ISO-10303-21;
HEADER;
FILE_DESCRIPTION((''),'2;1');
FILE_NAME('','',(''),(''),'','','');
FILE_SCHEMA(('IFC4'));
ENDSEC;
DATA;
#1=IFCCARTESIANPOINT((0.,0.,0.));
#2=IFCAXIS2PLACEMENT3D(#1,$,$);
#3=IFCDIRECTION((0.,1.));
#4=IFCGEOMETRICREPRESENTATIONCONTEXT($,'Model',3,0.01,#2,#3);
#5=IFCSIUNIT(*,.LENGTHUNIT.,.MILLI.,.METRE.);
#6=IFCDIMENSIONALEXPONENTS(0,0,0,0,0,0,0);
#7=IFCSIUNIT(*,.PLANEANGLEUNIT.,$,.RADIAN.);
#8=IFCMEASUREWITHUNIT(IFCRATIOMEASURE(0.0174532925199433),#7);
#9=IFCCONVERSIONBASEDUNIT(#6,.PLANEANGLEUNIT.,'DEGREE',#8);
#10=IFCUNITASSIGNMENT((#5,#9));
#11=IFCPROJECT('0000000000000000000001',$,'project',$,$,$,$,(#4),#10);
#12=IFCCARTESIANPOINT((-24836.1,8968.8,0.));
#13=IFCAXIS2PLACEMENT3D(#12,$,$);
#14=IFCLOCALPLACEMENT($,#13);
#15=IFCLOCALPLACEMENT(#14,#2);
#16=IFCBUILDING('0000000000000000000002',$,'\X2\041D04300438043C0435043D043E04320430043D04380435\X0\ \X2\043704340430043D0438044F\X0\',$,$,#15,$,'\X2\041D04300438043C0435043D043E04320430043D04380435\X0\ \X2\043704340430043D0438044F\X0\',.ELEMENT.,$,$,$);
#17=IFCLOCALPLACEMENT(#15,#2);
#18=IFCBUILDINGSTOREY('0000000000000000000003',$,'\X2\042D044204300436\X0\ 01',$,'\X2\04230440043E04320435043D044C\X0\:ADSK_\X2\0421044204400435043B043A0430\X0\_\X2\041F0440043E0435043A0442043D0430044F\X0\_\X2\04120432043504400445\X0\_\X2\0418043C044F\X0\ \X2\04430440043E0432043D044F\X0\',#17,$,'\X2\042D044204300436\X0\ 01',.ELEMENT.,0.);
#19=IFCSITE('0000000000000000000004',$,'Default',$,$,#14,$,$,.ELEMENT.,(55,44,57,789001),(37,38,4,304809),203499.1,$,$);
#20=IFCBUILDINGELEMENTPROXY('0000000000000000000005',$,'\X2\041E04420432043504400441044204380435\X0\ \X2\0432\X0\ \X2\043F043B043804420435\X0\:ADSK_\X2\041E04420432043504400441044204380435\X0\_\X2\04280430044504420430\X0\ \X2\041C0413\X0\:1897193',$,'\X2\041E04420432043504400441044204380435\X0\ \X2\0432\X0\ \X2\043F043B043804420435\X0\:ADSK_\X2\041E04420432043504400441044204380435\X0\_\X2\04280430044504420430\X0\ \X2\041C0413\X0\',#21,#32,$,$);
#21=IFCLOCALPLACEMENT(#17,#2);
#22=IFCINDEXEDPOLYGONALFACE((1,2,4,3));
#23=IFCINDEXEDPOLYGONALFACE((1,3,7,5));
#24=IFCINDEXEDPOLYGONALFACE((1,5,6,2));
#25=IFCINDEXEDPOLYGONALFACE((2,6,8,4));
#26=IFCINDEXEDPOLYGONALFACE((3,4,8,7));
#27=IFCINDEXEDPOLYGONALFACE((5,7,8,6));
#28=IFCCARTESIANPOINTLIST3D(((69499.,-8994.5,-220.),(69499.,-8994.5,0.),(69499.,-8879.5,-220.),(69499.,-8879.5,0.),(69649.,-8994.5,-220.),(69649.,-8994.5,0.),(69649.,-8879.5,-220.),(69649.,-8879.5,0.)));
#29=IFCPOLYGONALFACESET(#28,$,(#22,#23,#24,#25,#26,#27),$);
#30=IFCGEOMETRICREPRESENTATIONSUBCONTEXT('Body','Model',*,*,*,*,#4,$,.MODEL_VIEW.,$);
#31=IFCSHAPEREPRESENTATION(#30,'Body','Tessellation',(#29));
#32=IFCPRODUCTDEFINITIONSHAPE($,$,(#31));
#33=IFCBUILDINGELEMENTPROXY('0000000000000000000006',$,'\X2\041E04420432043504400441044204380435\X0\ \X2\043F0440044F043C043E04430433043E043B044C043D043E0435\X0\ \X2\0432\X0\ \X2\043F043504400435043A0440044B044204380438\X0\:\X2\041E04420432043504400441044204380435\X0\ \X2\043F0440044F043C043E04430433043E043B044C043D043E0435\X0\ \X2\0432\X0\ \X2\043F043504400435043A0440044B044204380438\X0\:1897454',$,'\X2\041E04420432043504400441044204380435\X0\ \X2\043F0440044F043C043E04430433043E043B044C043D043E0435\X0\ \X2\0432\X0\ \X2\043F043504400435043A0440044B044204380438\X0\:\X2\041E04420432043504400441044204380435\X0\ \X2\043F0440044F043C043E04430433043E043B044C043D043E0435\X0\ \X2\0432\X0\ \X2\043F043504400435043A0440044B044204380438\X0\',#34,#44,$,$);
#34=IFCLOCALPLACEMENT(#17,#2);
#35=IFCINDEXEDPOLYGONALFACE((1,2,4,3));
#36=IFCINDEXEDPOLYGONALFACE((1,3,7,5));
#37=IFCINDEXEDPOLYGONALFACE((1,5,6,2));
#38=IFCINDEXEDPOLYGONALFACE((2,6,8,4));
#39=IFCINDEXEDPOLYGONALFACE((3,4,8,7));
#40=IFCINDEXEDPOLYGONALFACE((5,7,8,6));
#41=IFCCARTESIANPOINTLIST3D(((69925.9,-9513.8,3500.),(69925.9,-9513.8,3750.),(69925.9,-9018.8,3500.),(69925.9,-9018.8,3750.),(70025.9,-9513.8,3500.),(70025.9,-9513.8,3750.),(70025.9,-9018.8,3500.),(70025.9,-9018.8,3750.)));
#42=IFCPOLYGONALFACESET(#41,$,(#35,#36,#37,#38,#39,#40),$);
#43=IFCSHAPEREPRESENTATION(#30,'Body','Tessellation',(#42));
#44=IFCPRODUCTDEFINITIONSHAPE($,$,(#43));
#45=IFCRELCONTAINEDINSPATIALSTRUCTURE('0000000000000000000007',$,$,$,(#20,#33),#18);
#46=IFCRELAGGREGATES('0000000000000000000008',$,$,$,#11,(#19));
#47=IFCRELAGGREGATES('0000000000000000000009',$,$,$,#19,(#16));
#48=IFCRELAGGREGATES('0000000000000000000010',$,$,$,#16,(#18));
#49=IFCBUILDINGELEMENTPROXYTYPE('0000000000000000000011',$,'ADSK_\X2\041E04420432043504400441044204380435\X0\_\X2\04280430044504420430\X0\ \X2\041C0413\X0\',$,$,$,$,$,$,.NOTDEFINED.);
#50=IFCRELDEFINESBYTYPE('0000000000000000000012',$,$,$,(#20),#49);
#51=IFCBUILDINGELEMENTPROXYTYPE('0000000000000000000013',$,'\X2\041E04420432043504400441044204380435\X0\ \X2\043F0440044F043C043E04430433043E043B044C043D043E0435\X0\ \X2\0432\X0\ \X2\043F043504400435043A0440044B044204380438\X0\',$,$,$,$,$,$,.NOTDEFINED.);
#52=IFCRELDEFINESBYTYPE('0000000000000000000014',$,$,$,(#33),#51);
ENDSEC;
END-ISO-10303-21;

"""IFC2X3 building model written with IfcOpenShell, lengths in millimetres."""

from ifc_helpers import new_model, entity, si_unit, converted_unit, direction, frame, origin, origin_2d_with_axis, place, context, subcontext, project, spatial, rectangle, extrude, type_object, element, save


model = new_model("IFC2X3")

# Units and contexts
model_context = context("Model", 3, precision=0.01, world=origin(), true_north=direction((0.0, 1.0)))
body_context = subcontext(model_context, "Body", "Model", "MODEL_VIEW")
ifc_project = project(units=[si_unit("LENGTHUNIT", "METRE", prefix="MILLI"), converted_unit("PLANEANGLEUNIT", "DEGREE", entity("IfcRatioMeasure", 0.0174532925199433), si_unit("PLANEANGLEUNIT", "RADIAN"), dimensions=[0, 0, 0, 0, 0, 0, 0])], contexts=[model_context])

# Site, building, storey
site_placement = place(None, frame((-24836.1, 8968.8, 0.0)))
site = spatial("IfcSite", under=ifc_project, at=site_placement, Name="Default", CompositionType="ELEMENT", RefLatitude=(55, 44, 57, 789001), RefLongitude=(37, 38, 4, 304809), RefElevation=203499.1)
building_placement = place(site_placement, origin())
building = spatial("IfcBuilding", under=site, at=building_placement, Name="Наименование здания", LongName="Наименование здания", CompositionType="ELEMENT")
storey_placement = place(building_placement, origin())
storey = spatial("IfcBuildingStorey", under=building, at=storey_placement, Name="Этаж 01", ObjectType="Уровень:ADSK_Стрелка_Проектная_Вверх_Имя уровня", LongName="Этаж 01", CompositionType="ELEMENT", Elevation=0.0)

# Building element proxies
building_element_proxy_type_1 = type_object("IfcBuildingElementProxyType", Name="ADSK_Отверстие_Шахта МГ", PredefinedType="NOTDEFINED")
proxy_1_placement = place(storey_placement, frame((69499.0, -8994.5, -220.0)))
element("IfcBuildingElementProxy", 1, at=proxy_1_placement, inside=storey, type_object=building_element_proxy_type_1, Name="Отверстие в плите:ADSK_Отверстие_Шахта МГ:1897193", ObjectType="Отверстие в плите:ADSK_Отверстие_Шахта МГ", context=body_context, shape_type="SweptSolid", body=[
    extrude(rectangle(XDim=150.0, YDim=115.0, at=origin_2d_with_axis()), frame((75.0, 57.5, 0.0)), (0.0, 0.0, 1.0), 220.0),
])
building_element_proxy_type_2 = type_object("IfcBuildingElementProxyType", Name="Отверстие прямоугольное в перекрытии", PredefinedType="NOTDEFINED")
proxy_2_placement = place(storey_placement, frame((69925.9, -9513.8, 3500.0)))
element("IfcBuildingElementProxy", 2, at=proxy_2_placement, inside=storey, type_object=building_element_proxy_type_2, Name="Отверстие прямоугольное в перекрытии:Отверстие прямоугольное в перекрытии:1897454", ObjectType="Отверстие прямоугольное в перекрытии:Отверстие прямоугольное в перекрытии", context=body_context, shape_type="SweptSolid", body=[
    extrude(rectangle(XDim=495.0, YDim=100.0, at=origin_2d_with_axis()), frame((50.0, 247.5, 0.0), z_axis=(0.0, 0.0, 1.0), x_axis=(0.0, -1.0, 0.0)), (0.0, 0.0, 1.0), 250.0),
])

save(model, "model.ifc")
